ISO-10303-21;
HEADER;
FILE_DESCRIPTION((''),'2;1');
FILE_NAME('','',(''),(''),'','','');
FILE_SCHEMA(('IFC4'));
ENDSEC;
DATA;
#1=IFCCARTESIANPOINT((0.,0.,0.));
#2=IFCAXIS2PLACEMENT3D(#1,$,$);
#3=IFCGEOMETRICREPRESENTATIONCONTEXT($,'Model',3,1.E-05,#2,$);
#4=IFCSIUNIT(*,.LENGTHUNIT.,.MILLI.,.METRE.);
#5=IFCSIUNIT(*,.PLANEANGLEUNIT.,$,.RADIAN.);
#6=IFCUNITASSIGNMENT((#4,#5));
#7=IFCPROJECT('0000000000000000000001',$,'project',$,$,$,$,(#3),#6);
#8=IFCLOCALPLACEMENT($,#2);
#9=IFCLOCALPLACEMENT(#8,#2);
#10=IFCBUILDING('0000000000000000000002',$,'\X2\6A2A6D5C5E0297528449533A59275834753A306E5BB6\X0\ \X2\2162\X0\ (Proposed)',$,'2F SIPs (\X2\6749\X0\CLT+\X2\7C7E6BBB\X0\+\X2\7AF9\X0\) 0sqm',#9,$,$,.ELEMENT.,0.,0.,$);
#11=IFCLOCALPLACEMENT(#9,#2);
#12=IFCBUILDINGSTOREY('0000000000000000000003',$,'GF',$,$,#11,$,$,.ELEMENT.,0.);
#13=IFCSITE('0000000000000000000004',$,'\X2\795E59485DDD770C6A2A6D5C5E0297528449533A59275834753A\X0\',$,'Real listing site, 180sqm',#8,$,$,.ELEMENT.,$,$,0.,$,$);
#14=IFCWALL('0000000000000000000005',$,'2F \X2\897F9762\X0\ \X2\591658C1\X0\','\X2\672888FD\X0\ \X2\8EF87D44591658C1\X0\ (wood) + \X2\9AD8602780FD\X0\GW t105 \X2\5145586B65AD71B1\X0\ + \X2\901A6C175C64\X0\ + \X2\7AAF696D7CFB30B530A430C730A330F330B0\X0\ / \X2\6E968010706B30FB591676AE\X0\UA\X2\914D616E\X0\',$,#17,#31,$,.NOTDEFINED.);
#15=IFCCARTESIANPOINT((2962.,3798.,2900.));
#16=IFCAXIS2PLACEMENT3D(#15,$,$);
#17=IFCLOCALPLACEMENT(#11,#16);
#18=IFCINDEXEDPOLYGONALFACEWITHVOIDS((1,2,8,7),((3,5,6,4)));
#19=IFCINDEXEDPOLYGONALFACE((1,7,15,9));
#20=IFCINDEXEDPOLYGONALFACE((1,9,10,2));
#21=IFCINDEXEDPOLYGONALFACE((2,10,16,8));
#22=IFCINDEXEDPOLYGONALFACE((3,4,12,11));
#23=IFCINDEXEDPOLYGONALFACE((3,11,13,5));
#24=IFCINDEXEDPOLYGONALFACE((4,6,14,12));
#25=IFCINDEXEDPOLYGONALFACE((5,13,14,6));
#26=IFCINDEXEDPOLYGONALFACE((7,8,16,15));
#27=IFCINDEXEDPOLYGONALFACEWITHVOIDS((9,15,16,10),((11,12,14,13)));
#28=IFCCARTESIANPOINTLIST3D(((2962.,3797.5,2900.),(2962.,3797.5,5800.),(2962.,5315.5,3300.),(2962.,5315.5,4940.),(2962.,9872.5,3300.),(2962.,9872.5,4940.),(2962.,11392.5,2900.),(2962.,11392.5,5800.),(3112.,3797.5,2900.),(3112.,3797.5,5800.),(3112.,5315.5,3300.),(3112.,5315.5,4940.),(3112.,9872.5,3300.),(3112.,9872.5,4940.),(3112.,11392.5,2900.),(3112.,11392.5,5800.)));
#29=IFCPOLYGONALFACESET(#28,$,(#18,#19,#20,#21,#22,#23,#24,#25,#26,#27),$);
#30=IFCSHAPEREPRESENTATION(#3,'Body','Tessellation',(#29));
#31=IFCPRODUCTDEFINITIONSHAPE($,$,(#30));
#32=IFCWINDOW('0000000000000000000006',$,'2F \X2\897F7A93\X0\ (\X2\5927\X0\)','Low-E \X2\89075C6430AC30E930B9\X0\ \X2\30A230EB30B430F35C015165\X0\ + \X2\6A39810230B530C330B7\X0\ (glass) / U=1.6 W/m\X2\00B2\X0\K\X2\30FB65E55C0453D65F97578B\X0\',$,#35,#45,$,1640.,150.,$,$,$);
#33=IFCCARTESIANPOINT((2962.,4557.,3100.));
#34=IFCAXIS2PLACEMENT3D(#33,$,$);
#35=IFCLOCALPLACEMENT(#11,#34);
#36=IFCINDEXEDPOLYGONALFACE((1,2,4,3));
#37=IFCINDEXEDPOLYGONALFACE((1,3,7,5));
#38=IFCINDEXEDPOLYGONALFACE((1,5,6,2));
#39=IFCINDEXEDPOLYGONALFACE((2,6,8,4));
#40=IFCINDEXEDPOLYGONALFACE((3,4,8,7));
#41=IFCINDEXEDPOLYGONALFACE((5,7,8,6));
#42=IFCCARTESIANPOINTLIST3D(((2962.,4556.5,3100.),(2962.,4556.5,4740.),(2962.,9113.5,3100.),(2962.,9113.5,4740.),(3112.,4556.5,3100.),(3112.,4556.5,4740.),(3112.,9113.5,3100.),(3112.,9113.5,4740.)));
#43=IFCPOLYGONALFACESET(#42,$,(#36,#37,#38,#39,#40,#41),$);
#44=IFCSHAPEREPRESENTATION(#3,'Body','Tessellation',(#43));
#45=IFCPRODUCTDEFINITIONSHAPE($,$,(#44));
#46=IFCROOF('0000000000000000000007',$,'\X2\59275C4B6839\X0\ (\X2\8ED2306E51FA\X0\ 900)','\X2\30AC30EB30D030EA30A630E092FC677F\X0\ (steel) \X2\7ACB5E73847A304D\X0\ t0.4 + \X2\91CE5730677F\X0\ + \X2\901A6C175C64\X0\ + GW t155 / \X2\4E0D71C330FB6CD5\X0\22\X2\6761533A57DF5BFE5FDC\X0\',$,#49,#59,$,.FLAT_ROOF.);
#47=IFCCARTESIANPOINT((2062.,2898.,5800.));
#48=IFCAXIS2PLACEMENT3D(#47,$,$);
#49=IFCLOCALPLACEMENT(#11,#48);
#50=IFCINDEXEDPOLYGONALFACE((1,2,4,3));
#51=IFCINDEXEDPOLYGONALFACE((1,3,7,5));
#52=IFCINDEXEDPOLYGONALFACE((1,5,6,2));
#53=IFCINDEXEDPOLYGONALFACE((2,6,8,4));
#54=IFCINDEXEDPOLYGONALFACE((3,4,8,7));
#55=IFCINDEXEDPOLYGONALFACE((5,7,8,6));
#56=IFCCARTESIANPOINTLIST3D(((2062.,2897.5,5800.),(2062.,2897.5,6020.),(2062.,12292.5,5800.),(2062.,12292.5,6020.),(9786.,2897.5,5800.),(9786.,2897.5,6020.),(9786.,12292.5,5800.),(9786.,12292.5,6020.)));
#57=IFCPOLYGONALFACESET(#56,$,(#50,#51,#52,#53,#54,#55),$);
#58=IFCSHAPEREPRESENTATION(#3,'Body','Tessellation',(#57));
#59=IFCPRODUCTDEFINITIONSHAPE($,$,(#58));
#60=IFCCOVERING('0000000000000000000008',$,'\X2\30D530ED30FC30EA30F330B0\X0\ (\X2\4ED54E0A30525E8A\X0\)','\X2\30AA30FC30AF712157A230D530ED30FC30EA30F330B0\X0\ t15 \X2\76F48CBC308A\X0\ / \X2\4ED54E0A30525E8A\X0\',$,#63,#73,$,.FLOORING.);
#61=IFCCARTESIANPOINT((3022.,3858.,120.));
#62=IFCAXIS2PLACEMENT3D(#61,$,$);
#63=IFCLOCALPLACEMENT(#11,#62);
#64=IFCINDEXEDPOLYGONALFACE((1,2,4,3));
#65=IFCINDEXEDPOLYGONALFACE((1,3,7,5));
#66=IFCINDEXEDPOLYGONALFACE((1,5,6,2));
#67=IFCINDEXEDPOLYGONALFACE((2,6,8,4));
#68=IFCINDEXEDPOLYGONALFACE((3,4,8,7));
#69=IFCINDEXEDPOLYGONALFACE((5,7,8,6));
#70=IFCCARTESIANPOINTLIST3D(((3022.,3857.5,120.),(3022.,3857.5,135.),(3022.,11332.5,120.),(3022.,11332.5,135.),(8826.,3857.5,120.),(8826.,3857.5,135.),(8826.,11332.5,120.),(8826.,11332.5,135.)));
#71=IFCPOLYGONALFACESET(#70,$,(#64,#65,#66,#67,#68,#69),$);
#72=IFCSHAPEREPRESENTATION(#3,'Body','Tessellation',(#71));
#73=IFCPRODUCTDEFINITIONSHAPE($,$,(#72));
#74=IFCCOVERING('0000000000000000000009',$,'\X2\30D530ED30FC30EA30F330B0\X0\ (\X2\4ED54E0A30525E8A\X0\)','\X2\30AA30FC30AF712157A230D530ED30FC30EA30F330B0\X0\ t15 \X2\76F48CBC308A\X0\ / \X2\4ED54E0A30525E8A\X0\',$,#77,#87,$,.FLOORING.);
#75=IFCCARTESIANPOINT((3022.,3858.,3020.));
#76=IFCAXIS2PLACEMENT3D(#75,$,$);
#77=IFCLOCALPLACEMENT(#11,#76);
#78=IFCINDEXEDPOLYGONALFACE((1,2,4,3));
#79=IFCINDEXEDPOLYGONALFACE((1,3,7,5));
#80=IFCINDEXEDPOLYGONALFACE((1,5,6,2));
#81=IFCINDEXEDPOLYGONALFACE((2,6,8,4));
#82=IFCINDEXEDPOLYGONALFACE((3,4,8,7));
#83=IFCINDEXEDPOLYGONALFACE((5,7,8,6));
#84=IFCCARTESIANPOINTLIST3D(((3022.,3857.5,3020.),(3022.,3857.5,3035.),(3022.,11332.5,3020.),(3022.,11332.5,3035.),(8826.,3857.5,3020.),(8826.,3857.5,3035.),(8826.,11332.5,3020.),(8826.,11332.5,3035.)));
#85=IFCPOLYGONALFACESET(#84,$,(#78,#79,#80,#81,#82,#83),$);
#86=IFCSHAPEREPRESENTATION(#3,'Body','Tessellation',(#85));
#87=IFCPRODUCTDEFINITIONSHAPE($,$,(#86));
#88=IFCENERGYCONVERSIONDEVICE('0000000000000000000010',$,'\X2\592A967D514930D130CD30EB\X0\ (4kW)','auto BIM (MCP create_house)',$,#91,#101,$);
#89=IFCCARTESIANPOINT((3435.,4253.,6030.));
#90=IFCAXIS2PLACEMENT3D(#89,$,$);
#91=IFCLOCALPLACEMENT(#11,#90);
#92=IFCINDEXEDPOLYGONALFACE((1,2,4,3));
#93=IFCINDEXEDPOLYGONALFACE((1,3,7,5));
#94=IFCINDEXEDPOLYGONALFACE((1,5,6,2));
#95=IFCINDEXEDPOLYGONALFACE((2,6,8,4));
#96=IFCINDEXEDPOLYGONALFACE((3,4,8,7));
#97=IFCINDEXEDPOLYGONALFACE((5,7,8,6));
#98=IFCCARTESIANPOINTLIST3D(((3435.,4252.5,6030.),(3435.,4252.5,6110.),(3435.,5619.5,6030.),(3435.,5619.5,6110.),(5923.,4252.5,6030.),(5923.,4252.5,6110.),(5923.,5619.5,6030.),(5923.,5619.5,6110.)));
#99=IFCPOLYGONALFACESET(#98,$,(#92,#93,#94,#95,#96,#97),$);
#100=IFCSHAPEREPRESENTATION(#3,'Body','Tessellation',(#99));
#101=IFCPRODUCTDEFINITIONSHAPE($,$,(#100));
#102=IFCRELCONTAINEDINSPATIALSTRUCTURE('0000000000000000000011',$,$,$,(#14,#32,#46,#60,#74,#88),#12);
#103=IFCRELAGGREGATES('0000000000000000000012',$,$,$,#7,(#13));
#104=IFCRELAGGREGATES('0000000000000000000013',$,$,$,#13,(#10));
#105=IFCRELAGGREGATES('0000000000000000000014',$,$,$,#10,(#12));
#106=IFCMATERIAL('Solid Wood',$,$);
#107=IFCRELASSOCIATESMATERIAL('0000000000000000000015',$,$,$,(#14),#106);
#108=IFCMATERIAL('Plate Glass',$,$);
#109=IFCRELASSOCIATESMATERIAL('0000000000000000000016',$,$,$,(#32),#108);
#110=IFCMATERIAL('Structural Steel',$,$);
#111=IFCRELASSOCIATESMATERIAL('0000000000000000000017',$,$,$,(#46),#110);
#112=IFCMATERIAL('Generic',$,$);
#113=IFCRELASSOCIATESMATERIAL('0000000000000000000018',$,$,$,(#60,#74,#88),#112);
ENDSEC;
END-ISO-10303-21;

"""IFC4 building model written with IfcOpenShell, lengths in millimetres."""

from ifc_helpers import new_model, si_unit, frame, frame_2d, origin, place, context, project, spatial, rectangle, extrude, material, element, fill, save


model = new_model("IFC4")

# Units and contexts
model_context = context("Model", 3, precision=1e-05, world=origin())
ifc_project = project(units=[si_unit("LENGTHUNIT", "METRE", prefix="MILLI"), si_unit("PLANEANGLEUNIT", "RADIAN")], contexts=[model_context])

# Site, building, storey
site_placement = place(None, origin())
site = spatial("IfcSite", under=ifc_project, at=site_placement, Name="神奈川県横浜市青葉区大場町", ObjectType="Real listing site, 180sqm", CompositionType="ELEMENT", RefElevation=0.0)
building_placement = place(site_placement, origin())
building = spatial("IfcBuilding", under=site, at=building_placement, Name="横浜市青葉区大場町の家 Ⅲ (Proposed)", ObjectType="2F SIPs (杉CLT+籾殻+竹) 0sqm", CompositionType="ELEMENT", ElevationOfRefHeight=0.0, ElevationOfTerrain=0.0)
storey_placement = place(building_placement, origin())
storey = spatial("IfcBuildingStorey", under=building, at=storey_placement, Name="GF", CompositionType="ELEMENT", Elevation=0.0)

# Shared definitions
ifc_material_1 = material(Name="Solid Wood")

# Shared definitions
ifc_material_2 = material(Name="Plate Glass")

# Wall, opening, window
wall_1_placement = place(storey_placement, frame((2962.0, 3798.0, 2900.0)))
wall_1 = element("IfcWall", 1, at=wall_1_placement, inside=storey, material=ifc_material_1, Name="2F 西面 外壁", Description="木製 軸組外壁 (wood) + 高性能GW t105 充填断熱 + 通気層 + 窯業系サイディング / 準耐火・外皮UA配慮", PredefinedType="NOTDEFINED", context=model_context, shape_type="SweptSolid", body=[
    extrude(rectangle(XDim=150.0, YDim=7595.0, at=frame_2d((75.0, 3797.0))), frame((2962.0, 3798.0, 2900.0)), (0.0, 0.0, 1.0), 2900.0),
])
opening_1_placement = place(storey_placement, frame((2962.0, 4557.0, 3100.0)))
opening_1 = element("IfcOpeningElement", 2, at=opening_1_placement, cuts=wall_1, PredefinedType="NOTDEFINED", context=model_context, shape_type="SweptSolid", body=[
    extrude(rectangle(XDim=150.0, YDim=4557.0, at=frame_2d((75.0, 2278.0))), frame((2962.0, 4557.0, 3100.0)), (0.0, 0.0, 1.0), 1640.0),
])
window_1_placement = place(storey_placement, frame((2962.0, 4557.0, 3100.0)))
window_1 = element("IfcWindow", 3, at=window_1_placement, inside=storey, material=ifc_material_2, Name="2F 西窓 (大)", Description="Low-E 複層ガラス アルゴン封入 + 樹脂サッシ (glass) / U=1.6 W/m²K・日射取得型", OverallHeight=1640.0, OverallWidth=150.0, context=model_context, shape_type="SweptSolid", body=[
    extrude(rectangle(XDim=150.0, YDim=4557.0, at=frame_2d((75.0, 2278.0))), frame((2962.0, 4557.0, 3100.0)), (0.0, 0.0, 1.0), 1640.0),
])
fill(opening_1, window_1)

# Roof
ifc_material_3 = material(Name="Structural Steel")
roof_placement = place(storey_placement, frame((2062.0, 2898.0, 5800.0)))
element("IfcRoof", 4, at=roof_placement, inside=storey, material=ifc_material_3, Name="大屋根 (軒の出 900)", Description="ガルバリウム鋼板 (steel) 立平葺き t0.4 + 野地板 + 通気層 + GW t155 / 不燃・法22条区域対応", PredefinedType="FLAT_ROOF", context=model_context, shape_type="SweptSolid", body=[
    extrude(rectangle(XDim=7724.0, YDim=9395.0, at=frame_2d((3862.0, 4697.0))), frame((2062.0, 2898.0, 5800.0)), (0.0, 0.0, 1.0), 220.0),
])

# Coverings
ifc_material_4 = material(Name="Generic")
covering_1_placement = place(storey_placement, frame((3022.0, 3858.0, 120.0)))
element("IfcCovering", 5, at=covering_1_placement, inside=storey, material=ifc_material_4, Name="フローリング (仕上げ床)", Description="オーク無垢フローリング t15 直貼り / 仕上げ床", PredefinedType="FLOORING", context=model_context, shape_type="SweptSolid", body=[
    extrude(rectangle(XDim=5804.0, YDim=7475.0, at=frame_2d((2902.0, 3737.0))), frame((3022.0, 3858.0, 120.0)), (0.0, 0.0, 1.0), 15.0),
])
covering_2_placement = place(storey_placement, frame((3022.0, 3858.0, 3020.0)))
element("IfcCovering", 6, at=covering_2_placement, inside=storey, material=ifc_material_4, Name="フローリング (仕上げ床)", Description="オーク無垢フローリング t15 直貼り / 仕上げ床", PredefinedType="FLOORING", context=model_context, shape_type="SweptSolid", body=[
    extrude(rectangle(XDim=5804.0, YDim=7475.0, at=frame_2d((2902.0, 3737.0))), frame((3022.0, 3858.0, 3020.0)), (0.0, 0.0, 1.0), 15.0),
])

# Energy conversion device
energy_conversion_device_placement = place(storey_placement, frame((3435.0, 4253.0, 6030.0)))
element("IfcEnergyConversionDevice", 7, at=energy_conversion_device_placement, inside=storey, material=ifc_material_4, Name="太陽光パネル (4kW)", Description="auto BIM (MCP create_house)", context=model_context, shape_type="SweptSolid", body=[
    extrude(rectangle(XDim=2488.0, YDim=1367.0, at=frame_2d((1244.0, 683.0))), frame((3435.0, 4253.0, 6030.0)), (0.0, 0.0, 1.0), 80.0),
])

save(model, "model.ifc")
